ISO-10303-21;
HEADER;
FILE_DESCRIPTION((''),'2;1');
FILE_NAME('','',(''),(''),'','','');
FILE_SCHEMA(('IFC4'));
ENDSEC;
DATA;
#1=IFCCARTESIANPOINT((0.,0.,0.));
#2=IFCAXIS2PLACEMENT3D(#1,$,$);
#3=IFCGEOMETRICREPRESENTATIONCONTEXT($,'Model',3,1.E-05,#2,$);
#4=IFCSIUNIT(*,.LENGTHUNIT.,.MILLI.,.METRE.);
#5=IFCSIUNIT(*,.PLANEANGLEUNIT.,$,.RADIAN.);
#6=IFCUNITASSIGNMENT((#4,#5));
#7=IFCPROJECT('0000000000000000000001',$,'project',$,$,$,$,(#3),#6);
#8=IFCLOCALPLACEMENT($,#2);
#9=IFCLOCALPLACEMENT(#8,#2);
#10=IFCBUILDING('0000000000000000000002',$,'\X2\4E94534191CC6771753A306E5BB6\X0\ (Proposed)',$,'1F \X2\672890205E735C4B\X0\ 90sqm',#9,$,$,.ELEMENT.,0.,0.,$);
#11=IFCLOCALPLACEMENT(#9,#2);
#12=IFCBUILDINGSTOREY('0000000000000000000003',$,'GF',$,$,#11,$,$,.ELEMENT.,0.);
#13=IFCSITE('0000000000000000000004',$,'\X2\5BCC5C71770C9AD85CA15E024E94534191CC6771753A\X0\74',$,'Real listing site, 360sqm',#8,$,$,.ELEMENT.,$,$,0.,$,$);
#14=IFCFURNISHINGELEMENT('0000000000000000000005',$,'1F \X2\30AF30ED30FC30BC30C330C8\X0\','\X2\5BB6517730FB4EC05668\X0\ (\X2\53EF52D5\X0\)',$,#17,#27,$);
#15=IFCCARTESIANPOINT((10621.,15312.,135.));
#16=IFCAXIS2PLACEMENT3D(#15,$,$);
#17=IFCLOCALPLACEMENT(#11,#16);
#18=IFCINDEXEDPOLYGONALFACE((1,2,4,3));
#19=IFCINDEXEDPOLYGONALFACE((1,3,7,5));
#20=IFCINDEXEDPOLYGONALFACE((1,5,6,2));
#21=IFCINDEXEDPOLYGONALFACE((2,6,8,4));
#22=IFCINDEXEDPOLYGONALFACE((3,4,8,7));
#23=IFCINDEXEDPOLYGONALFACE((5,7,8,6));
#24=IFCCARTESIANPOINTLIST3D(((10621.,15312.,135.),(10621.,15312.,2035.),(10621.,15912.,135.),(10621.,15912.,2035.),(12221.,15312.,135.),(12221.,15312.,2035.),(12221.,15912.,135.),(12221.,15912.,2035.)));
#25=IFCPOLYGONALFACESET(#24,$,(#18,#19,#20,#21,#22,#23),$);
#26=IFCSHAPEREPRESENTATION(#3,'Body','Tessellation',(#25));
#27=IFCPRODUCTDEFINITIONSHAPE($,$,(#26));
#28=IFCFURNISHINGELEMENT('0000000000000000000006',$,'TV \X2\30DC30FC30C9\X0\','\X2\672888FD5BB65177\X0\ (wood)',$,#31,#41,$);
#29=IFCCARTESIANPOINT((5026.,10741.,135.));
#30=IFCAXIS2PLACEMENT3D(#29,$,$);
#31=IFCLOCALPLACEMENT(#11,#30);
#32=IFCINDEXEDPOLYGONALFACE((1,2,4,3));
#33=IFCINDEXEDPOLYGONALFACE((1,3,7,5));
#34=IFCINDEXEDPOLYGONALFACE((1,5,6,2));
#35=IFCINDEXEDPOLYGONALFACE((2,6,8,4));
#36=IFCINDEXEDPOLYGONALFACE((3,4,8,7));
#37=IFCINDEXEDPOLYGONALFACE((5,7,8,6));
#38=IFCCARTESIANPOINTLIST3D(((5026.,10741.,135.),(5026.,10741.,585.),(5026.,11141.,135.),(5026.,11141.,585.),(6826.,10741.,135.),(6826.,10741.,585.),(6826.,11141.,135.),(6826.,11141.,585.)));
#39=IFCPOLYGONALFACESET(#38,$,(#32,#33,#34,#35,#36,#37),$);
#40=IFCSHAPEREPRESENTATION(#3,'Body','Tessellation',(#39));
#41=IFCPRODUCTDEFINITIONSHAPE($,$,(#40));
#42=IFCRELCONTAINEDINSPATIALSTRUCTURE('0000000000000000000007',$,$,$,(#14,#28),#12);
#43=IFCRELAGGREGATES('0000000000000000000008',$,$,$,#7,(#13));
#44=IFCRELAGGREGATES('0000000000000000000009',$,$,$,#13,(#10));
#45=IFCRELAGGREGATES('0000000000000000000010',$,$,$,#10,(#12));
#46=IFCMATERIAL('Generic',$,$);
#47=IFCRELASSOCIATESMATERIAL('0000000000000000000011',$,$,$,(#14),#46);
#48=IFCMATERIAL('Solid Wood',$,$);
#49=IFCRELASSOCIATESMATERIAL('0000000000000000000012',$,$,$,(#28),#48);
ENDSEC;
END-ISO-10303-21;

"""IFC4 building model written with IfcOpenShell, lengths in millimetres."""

from ifc_helpers import new_model, si_unit, frame, frame_2d, origin, place, context, project, spatial, rectangle, extrude, material, element, save


model = new_model("IFC4")

# Units and contexts
model_context = context("Model", 3, precision=1e-05, world=origin())
ifc_project = project(units=[si_unit("LENGTHUNIT", "METRE", prefix="MILLI"), si_unit("PLANEANGLEUNIT", "RADIAN")], contexts=[model_context])

# Site, building, storey
site_placement = place(None, origin())
site = spatial("IfcSite", under=ifc_project, at=site_placement, Name="富山県高岡市五十里東町74", ObjectType="Real listing site, 360sqm", CompositionType="ELEMENT", RefElevation=0.0)
building_placement = place(site_placement, origin())
building = spatial("IfcBuilding", under=site, at=building_placement, Name="五十里東町の家 (Proposed)", ObjectType="1F 木造平屋 90sqm", CompositionType="ELEMENT", ElevationOfRefHeight=0.0, ElevationOfTerrain=0.0)
storey_placement = place(building_placement, origin())
storey = spatial("IfcBuildingStorey", under=building, at=storey_placement, Name="GF", CompositionType="ELEMENT", Elevation=0.0)

# Shared definitions
ifc_material_1 = material(Name="Solid Wood")

# Shared definitions
ifc_material_2 = material(Name="Generic")

# Furnishing elements
furnishing_1_placement = place(storey_placement, frame((10621.0, 15312.0, 135.0)))
element("IfcFurnishingElement", 1, at=furnishing_1_placement, inside=storey, material=ifc_material_2, Name="1F クローゼット", Description="家具・什器 (可動)", context=model_context, shape_type="SweptSolid", body=[
    extrude(rectangle(XDim=1600.0, YDim=600.0, at=frame_2d((800.0, 300.0))), frame((10621.0, 15312.0, 135.0)), (0.0, 0.0, 1.0), 1900.0),
])
furnishing_2_placement = place(storey_placement, frame((5026.0, 10741.0, 135.0)))
element("IfcFurnishingElement", 2, at=furnishing_2_placement, inside=storey, material=ifc_material_1, Name="TV ボード", Description="木製家具 (wood)", context=model_context, shape_type="SweptSolid", body=[
    extrude(rectangle(XDim=1800.0, YDim=400.0, at=frame_2d((900.0, 200.0))), frame((5026.0, 10741.0, 135.0)), (0.0, 0.0, 1.0), 450.0),
])

save(model, "model.ifc")
